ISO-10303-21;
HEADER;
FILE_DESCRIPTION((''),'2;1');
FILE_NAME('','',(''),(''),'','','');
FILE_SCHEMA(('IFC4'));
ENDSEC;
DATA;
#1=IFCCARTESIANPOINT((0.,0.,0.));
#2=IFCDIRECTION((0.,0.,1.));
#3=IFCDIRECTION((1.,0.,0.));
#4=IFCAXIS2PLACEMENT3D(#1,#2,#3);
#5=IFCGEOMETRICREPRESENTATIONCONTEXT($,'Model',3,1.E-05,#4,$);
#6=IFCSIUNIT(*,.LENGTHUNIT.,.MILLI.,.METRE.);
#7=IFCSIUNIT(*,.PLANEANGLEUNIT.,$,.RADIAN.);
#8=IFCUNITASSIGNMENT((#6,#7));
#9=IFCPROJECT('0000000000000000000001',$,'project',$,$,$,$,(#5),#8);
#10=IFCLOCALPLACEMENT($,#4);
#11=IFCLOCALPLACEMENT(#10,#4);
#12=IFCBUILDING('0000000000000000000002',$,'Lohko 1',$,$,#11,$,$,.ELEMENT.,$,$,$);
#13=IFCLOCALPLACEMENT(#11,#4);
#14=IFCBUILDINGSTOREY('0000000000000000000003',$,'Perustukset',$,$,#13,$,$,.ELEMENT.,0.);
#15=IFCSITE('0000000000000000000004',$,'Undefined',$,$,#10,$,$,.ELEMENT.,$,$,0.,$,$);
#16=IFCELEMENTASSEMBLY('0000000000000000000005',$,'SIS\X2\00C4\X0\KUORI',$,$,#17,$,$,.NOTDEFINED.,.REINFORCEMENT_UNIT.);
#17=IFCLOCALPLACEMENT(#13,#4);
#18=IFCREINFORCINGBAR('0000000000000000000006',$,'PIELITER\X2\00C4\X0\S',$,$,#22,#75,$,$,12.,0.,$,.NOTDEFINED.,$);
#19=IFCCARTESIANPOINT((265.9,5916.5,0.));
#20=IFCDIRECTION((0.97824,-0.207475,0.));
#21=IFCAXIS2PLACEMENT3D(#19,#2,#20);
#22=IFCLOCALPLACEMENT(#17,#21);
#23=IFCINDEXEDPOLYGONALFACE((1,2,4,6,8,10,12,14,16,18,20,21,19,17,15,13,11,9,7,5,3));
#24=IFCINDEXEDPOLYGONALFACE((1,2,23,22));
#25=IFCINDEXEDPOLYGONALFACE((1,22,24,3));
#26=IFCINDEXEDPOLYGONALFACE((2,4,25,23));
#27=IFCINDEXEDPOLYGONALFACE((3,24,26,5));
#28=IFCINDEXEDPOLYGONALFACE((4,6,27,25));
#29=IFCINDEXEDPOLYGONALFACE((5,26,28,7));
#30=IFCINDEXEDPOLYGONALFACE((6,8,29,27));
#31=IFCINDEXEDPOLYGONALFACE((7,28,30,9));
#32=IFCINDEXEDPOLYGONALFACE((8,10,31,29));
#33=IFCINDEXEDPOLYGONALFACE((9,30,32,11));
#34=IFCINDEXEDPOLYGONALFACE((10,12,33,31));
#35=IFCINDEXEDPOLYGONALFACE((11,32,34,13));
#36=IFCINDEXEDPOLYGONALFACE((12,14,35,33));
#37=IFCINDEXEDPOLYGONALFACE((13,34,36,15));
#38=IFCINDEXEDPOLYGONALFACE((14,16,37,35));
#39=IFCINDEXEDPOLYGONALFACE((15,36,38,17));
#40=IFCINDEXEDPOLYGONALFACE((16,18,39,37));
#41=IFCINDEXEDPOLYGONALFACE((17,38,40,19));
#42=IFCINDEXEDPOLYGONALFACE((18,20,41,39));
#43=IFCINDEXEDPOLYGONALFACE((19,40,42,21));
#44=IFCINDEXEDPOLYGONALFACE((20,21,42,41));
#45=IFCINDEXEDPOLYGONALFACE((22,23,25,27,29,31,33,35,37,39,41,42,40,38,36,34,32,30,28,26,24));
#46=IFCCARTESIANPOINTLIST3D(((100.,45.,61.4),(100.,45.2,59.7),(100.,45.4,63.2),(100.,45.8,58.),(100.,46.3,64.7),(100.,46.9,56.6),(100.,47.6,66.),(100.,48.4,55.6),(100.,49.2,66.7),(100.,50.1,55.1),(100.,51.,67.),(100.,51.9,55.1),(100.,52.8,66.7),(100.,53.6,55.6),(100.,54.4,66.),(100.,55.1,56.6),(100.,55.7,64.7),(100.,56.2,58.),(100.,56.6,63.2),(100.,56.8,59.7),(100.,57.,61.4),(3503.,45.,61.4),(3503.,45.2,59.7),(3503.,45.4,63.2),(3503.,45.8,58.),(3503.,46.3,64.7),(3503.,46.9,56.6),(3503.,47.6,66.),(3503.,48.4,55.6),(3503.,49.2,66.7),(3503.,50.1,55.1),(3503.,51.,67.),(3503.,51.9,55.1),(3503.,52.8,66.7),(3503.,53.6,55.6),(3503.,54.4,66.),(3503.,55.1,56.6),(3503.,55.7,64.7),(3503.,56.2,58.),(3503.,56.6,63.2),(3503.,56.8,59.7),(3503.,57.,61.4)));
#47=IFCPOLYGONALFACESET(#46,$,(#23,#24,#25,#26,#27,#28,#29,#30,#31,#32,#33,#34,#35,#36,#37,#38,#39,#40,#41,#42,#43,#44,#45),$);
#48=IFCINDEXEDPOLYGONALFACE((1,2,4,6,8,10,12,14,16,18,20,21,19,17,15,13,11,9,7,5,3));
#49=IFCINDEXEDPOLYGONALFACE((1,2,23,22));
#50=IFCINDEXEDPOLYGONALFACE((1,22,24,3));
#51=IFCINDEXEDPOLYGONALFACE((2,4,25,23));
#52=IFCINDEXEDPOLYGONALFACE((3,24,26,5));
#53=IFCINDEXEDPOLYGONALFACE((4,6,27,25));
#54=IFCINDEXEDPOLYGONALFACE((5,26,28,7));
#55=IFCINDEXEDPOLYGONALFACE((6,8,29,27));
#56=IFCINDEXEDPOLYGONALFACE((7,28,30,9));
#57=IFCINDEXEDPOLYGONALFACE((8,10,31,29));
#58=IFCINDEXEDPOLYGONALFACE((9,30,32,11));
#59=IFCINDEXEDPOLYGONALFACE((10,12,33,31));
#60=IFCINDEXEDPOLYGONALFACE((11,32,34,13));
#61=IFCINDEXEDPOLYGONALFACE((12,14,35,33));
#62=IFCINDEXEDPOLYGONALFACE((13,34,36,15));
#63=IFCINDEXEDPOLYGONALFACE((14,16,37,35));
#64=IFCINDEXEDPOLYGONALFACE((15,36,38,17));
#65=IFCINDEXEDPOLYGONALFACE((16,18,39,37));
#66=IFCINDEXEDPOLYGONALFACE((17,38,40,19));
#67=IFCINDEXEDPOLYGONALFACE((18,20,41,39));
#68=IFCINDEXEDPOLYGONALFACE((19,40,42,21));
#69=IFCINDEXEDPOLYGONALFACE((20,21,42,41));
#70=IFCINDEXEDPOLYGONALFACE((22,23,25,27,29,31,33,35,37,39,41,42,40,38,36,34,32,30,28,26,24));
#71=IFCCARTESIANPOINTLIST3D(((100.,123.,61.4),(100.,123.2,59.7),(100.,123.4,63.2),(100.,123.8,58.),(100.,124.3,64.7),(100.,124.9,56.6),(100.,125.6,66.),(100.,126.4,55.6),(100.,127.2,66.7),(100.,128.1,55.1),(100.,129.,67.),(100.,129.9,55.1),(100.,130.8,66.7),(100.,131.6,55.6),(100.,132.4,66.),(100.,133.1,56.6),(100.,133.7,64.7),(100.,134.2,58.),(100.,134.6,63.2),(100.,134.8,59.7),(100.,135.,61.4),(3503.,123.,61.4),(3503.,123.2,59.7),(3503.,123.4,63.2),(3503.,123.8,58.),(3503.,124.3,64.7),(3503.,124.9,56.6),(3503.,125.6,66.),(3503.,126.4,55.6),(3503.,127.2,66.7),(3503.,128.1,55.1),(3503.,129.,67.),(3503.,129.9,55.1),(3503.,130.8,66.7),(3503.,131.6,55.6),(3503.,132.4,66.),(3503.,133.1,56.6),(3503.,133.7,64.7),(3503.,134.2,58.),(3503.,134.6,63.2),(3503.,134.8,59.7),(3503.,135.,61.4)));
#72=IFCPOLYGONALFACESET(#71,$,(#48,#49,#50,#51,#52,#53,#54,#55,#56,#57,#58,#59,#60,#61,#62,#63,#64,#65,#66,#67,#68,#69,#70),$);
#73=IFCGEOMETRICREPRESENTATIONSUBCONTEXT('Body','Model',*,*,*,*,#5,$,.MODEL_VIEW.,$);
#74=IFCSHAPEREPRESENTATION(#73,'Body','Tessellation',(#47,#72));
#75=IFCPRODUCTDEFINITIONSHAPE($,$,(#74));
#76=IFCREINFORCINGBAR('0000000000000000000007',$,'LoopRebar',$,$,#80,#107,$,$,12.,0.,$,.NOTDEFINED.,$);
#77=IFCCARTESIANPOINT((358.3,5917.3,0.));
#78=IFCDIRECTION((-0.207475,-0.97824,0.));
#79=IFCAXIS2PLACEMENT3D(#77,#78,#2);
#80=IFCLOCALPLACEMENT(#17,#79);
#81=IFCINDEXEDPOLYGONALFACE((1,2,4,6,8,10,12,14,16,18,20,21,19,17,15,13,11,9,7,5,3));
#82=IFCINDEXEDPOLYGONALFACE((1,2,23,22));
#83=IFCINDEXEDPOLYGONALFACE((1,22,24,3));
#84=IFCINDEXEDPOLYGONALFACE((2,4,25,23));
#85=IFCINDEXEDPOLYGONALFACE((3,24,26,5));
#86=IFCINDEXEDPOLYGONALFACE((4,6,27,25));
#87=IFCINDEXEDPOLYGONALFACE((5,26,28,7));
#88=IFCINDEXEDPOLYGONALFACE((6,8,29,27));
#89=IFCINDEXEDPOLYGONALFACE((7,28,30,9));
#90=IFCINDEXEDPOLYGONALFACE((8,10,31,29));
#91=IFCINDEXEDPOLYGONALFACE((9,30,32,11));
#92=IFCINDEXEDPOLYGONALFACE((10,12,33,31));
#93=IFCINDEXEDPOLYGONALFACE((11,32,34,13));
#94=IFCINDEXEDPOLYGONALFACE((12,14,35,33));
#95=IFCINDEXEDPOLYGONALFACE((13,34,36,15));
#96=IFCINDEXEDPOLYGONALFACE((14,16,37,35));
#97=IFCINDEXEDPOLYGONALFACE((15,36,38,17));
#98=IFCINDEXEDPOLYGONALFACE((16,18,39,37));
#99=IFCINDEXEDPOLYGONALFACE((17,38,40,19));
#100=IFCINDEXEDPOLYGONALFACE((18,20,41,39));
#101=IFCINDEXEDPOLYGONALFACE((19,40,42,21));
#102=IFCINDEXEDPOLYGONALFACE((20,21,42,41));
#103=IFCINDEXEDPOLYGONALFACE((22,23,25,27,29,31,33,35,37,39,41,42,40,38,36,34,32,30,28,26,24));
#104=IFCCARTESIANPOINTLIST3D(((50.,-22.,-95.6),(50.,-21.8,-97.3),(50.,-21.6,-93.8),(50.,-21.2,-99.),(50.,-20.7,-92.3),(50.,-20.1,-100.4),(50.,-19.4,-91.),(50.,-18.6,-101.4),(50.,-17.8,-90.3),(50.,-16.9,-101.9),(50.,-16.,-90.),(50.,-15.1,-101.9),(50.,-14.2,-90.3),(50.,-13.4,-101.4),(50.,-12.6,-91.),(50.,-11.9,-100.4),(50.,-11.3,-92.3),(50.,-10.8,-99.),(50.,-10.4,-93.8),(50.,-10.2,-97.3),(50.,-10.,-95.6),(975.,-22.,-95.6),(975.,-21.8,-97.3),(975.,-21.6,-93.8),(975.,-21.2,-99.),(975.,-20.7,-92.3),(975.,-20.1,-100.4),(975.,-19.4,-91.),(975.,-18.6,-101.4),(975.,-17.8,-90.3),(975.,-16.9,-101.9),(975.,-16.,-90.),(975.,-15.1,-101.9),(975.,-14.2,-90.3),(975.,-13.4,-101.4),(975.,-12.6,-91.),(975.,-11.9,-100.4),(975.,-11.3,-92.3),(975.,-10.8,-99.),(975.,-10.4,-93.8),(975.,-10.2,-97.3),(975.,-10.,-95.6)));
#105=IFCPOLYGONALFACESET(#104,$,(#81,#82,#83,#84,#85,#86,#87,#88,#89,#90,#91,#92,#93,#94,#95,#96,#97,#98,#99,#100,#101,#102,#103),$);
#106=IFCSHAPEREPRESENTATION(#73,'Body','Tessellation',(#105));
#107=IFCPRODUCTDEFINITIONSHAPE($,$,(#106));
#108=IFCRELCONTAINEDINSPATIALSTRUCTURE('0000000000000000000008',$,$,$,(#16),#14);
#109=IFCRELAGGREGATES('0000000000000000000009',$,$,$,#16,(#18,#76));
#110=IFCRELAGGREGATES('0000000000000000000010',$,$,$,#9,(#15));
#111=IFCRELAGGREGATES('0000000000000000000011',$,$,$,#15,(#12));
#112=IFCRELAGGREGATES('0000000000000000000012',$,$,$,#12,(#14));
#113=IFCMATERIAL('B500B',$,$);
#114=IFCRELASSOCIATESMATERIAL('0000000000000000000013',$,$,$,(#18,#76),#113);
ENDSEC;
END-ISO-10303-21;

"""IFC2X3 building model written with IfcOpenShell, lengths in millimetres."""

from ifc_helpers import new_model, entity, si_unit, frame, origin_with_axes, place, context, subcontext, project, spatial, source, transform, mapped, material, element, aggregate, save


model = new_model("IFC2X3")

# Units and contexts
model_context = context("Model", 3, precision=1e-05, world=origin_with_axes())
body_context = subcontext(model_context, "Body", "Model", "MODEL_VIEW")
ifc_project = project(units=[si_unit("LENGTHUNIT", "METRE", prefix="MILLI"), si_unit("PLANEANGLEUNIT", "RADIAN")], contexts=[model_context])

# Site, building, storey
site_placement = place(None, origin_with_axes())
site = spatial("IfcSite", under=ifc_project, at=site_placement, Name="Undefined", CompositionType="ELEMENT", RefElevation=0.0)
building_placement = place(site_placement, origin_with_axes())
building = spatial("IfcBuilding", under=site, at=building_placement, Name="Lohko 1", CompositionType="ELEMENT")
storey_placement = place(building_placement, origin_with_axes())
storey = spatial("IfcBuildingStorey", under=building, at=storey_placement, Name="Perustukset", CompositionType="ELEMENT", Elevation=0.0)

# Element assembly, reinforcing bars
assembly_placement = place(storey_placement, origin_with_axes())
assembly = element("IfcElementAssembly", 1, at=assembly_placement, inside=storey, Name="SISÄKUORI", AssemblyPlace="NOTDEFINED", PredefinedType="REINFORCEMENT_UNIT")
ifc_material_1 = material(Name="B500B")
shared_shape_1 = source(origin_with_axes(), body_context, "Body", "AdvancedSweptSolid", [
    entity("IfcSweptDiskSolid", entity("IfcTrimmedCurve", entity("IfcLine", entity("IfcCartesianPoint", [0.0, 0.0, 0.0]), entity("IfcVector", entity("IfcDirection", [1.0, 0.0, 0.0]), 1.0)), [entity("IfcParameterValue", 0.0)], [entity("IfcParameterValue", 3402.999984)], True, "PARAMETER"), 6.0, None, 0.0, 3403.0),
])
shared_shape_2 = source(origin_with_axes(), body_context, "Body", "AdvancedSweptSolid", [
    entity("IfcSweptDiskSolid", entity("IfcTrimmedCurve", entity("IfcLine", entity("IfcCartesianPoint", [0.0, 0.0, 0.0]), entity("IfcVector", entity("IfcDirection", [1.0, 0.0, 0.0]), 1.0)), [entity("IfcParameterValue", 0.0)], [entity("IfcParameterValue", 3402.999984)], True, "PARAMETER"), 6.0, None, 0.0, 3403.0),
])
reinforcing_bar_1_placement = place(assembly_placement, frame((265.9, 5916.5, 0.0), z_axis=(0.0, 0.0, 1.0), x_axis=(0.97824, -0.207475, 0.0)))
reinforcing_bar_1 = element("IfcReinforcingBar", 2, at=reinforcing_bar_1_placement, material=ifc_material_1, Name="PIELITERÄS", BarRole="NOTDEFINED", CrossSectionArea=0.0, NominalDiameter=12.0, context=body_context, shape_type="MappedRepresentation", body=[
    mapped(shared_shape_1, transform((100.0, 51.0, 61.0))),
    mapped(shared_shape_2, transform((100.0, 129.0, 61.0))),
])
shared_shape_3 = source(origin_with_axes(), body_context, "Body", "AdvancedSweptSolid", [
    entity("IfcSweptDiskSolid", entity("IfcTrimmedCurve", entity("IfcLine", entity("IfcCartesianPoint", [0.0, 0.0, 0.0]), entity("IfcVector", entity("IfcDirection", [1.0, 0.0, 0.0]), 1.0)), [entity("IfcParameterValue", 0.0)], [entity("IfcParameterValue", 925.0)], True, "PARAMETER"), 6.0, None, 0.0, 925.0),
])
reinforcing_bar_2_placement = place(assembly_placement, frame((358.3, 5917.3, 0.0), z_axis=(-0.207475, -0.97824, 0.0), x_axis=(0.0, 0.0, 1.0)))
reinforcing_bar_2 = element("IfcReinforcingBar", 3, at=reinforcing_bar_2_placement, material=ifc_material_1, Name="LoopRebar", BarRole="NOTDEFINED", CrossSectionArea=0.0, NominalDiameter=12.0, context=body_context, shape_type="MappedRepresentation", body=[
    mapped(shared_shape_3, transform((50.0, -16.0, -96.0))),
])
aggregate(assembly, [reinforcing_bar_1, reinforcing_bar_2])

save(model, "model.ifc")
